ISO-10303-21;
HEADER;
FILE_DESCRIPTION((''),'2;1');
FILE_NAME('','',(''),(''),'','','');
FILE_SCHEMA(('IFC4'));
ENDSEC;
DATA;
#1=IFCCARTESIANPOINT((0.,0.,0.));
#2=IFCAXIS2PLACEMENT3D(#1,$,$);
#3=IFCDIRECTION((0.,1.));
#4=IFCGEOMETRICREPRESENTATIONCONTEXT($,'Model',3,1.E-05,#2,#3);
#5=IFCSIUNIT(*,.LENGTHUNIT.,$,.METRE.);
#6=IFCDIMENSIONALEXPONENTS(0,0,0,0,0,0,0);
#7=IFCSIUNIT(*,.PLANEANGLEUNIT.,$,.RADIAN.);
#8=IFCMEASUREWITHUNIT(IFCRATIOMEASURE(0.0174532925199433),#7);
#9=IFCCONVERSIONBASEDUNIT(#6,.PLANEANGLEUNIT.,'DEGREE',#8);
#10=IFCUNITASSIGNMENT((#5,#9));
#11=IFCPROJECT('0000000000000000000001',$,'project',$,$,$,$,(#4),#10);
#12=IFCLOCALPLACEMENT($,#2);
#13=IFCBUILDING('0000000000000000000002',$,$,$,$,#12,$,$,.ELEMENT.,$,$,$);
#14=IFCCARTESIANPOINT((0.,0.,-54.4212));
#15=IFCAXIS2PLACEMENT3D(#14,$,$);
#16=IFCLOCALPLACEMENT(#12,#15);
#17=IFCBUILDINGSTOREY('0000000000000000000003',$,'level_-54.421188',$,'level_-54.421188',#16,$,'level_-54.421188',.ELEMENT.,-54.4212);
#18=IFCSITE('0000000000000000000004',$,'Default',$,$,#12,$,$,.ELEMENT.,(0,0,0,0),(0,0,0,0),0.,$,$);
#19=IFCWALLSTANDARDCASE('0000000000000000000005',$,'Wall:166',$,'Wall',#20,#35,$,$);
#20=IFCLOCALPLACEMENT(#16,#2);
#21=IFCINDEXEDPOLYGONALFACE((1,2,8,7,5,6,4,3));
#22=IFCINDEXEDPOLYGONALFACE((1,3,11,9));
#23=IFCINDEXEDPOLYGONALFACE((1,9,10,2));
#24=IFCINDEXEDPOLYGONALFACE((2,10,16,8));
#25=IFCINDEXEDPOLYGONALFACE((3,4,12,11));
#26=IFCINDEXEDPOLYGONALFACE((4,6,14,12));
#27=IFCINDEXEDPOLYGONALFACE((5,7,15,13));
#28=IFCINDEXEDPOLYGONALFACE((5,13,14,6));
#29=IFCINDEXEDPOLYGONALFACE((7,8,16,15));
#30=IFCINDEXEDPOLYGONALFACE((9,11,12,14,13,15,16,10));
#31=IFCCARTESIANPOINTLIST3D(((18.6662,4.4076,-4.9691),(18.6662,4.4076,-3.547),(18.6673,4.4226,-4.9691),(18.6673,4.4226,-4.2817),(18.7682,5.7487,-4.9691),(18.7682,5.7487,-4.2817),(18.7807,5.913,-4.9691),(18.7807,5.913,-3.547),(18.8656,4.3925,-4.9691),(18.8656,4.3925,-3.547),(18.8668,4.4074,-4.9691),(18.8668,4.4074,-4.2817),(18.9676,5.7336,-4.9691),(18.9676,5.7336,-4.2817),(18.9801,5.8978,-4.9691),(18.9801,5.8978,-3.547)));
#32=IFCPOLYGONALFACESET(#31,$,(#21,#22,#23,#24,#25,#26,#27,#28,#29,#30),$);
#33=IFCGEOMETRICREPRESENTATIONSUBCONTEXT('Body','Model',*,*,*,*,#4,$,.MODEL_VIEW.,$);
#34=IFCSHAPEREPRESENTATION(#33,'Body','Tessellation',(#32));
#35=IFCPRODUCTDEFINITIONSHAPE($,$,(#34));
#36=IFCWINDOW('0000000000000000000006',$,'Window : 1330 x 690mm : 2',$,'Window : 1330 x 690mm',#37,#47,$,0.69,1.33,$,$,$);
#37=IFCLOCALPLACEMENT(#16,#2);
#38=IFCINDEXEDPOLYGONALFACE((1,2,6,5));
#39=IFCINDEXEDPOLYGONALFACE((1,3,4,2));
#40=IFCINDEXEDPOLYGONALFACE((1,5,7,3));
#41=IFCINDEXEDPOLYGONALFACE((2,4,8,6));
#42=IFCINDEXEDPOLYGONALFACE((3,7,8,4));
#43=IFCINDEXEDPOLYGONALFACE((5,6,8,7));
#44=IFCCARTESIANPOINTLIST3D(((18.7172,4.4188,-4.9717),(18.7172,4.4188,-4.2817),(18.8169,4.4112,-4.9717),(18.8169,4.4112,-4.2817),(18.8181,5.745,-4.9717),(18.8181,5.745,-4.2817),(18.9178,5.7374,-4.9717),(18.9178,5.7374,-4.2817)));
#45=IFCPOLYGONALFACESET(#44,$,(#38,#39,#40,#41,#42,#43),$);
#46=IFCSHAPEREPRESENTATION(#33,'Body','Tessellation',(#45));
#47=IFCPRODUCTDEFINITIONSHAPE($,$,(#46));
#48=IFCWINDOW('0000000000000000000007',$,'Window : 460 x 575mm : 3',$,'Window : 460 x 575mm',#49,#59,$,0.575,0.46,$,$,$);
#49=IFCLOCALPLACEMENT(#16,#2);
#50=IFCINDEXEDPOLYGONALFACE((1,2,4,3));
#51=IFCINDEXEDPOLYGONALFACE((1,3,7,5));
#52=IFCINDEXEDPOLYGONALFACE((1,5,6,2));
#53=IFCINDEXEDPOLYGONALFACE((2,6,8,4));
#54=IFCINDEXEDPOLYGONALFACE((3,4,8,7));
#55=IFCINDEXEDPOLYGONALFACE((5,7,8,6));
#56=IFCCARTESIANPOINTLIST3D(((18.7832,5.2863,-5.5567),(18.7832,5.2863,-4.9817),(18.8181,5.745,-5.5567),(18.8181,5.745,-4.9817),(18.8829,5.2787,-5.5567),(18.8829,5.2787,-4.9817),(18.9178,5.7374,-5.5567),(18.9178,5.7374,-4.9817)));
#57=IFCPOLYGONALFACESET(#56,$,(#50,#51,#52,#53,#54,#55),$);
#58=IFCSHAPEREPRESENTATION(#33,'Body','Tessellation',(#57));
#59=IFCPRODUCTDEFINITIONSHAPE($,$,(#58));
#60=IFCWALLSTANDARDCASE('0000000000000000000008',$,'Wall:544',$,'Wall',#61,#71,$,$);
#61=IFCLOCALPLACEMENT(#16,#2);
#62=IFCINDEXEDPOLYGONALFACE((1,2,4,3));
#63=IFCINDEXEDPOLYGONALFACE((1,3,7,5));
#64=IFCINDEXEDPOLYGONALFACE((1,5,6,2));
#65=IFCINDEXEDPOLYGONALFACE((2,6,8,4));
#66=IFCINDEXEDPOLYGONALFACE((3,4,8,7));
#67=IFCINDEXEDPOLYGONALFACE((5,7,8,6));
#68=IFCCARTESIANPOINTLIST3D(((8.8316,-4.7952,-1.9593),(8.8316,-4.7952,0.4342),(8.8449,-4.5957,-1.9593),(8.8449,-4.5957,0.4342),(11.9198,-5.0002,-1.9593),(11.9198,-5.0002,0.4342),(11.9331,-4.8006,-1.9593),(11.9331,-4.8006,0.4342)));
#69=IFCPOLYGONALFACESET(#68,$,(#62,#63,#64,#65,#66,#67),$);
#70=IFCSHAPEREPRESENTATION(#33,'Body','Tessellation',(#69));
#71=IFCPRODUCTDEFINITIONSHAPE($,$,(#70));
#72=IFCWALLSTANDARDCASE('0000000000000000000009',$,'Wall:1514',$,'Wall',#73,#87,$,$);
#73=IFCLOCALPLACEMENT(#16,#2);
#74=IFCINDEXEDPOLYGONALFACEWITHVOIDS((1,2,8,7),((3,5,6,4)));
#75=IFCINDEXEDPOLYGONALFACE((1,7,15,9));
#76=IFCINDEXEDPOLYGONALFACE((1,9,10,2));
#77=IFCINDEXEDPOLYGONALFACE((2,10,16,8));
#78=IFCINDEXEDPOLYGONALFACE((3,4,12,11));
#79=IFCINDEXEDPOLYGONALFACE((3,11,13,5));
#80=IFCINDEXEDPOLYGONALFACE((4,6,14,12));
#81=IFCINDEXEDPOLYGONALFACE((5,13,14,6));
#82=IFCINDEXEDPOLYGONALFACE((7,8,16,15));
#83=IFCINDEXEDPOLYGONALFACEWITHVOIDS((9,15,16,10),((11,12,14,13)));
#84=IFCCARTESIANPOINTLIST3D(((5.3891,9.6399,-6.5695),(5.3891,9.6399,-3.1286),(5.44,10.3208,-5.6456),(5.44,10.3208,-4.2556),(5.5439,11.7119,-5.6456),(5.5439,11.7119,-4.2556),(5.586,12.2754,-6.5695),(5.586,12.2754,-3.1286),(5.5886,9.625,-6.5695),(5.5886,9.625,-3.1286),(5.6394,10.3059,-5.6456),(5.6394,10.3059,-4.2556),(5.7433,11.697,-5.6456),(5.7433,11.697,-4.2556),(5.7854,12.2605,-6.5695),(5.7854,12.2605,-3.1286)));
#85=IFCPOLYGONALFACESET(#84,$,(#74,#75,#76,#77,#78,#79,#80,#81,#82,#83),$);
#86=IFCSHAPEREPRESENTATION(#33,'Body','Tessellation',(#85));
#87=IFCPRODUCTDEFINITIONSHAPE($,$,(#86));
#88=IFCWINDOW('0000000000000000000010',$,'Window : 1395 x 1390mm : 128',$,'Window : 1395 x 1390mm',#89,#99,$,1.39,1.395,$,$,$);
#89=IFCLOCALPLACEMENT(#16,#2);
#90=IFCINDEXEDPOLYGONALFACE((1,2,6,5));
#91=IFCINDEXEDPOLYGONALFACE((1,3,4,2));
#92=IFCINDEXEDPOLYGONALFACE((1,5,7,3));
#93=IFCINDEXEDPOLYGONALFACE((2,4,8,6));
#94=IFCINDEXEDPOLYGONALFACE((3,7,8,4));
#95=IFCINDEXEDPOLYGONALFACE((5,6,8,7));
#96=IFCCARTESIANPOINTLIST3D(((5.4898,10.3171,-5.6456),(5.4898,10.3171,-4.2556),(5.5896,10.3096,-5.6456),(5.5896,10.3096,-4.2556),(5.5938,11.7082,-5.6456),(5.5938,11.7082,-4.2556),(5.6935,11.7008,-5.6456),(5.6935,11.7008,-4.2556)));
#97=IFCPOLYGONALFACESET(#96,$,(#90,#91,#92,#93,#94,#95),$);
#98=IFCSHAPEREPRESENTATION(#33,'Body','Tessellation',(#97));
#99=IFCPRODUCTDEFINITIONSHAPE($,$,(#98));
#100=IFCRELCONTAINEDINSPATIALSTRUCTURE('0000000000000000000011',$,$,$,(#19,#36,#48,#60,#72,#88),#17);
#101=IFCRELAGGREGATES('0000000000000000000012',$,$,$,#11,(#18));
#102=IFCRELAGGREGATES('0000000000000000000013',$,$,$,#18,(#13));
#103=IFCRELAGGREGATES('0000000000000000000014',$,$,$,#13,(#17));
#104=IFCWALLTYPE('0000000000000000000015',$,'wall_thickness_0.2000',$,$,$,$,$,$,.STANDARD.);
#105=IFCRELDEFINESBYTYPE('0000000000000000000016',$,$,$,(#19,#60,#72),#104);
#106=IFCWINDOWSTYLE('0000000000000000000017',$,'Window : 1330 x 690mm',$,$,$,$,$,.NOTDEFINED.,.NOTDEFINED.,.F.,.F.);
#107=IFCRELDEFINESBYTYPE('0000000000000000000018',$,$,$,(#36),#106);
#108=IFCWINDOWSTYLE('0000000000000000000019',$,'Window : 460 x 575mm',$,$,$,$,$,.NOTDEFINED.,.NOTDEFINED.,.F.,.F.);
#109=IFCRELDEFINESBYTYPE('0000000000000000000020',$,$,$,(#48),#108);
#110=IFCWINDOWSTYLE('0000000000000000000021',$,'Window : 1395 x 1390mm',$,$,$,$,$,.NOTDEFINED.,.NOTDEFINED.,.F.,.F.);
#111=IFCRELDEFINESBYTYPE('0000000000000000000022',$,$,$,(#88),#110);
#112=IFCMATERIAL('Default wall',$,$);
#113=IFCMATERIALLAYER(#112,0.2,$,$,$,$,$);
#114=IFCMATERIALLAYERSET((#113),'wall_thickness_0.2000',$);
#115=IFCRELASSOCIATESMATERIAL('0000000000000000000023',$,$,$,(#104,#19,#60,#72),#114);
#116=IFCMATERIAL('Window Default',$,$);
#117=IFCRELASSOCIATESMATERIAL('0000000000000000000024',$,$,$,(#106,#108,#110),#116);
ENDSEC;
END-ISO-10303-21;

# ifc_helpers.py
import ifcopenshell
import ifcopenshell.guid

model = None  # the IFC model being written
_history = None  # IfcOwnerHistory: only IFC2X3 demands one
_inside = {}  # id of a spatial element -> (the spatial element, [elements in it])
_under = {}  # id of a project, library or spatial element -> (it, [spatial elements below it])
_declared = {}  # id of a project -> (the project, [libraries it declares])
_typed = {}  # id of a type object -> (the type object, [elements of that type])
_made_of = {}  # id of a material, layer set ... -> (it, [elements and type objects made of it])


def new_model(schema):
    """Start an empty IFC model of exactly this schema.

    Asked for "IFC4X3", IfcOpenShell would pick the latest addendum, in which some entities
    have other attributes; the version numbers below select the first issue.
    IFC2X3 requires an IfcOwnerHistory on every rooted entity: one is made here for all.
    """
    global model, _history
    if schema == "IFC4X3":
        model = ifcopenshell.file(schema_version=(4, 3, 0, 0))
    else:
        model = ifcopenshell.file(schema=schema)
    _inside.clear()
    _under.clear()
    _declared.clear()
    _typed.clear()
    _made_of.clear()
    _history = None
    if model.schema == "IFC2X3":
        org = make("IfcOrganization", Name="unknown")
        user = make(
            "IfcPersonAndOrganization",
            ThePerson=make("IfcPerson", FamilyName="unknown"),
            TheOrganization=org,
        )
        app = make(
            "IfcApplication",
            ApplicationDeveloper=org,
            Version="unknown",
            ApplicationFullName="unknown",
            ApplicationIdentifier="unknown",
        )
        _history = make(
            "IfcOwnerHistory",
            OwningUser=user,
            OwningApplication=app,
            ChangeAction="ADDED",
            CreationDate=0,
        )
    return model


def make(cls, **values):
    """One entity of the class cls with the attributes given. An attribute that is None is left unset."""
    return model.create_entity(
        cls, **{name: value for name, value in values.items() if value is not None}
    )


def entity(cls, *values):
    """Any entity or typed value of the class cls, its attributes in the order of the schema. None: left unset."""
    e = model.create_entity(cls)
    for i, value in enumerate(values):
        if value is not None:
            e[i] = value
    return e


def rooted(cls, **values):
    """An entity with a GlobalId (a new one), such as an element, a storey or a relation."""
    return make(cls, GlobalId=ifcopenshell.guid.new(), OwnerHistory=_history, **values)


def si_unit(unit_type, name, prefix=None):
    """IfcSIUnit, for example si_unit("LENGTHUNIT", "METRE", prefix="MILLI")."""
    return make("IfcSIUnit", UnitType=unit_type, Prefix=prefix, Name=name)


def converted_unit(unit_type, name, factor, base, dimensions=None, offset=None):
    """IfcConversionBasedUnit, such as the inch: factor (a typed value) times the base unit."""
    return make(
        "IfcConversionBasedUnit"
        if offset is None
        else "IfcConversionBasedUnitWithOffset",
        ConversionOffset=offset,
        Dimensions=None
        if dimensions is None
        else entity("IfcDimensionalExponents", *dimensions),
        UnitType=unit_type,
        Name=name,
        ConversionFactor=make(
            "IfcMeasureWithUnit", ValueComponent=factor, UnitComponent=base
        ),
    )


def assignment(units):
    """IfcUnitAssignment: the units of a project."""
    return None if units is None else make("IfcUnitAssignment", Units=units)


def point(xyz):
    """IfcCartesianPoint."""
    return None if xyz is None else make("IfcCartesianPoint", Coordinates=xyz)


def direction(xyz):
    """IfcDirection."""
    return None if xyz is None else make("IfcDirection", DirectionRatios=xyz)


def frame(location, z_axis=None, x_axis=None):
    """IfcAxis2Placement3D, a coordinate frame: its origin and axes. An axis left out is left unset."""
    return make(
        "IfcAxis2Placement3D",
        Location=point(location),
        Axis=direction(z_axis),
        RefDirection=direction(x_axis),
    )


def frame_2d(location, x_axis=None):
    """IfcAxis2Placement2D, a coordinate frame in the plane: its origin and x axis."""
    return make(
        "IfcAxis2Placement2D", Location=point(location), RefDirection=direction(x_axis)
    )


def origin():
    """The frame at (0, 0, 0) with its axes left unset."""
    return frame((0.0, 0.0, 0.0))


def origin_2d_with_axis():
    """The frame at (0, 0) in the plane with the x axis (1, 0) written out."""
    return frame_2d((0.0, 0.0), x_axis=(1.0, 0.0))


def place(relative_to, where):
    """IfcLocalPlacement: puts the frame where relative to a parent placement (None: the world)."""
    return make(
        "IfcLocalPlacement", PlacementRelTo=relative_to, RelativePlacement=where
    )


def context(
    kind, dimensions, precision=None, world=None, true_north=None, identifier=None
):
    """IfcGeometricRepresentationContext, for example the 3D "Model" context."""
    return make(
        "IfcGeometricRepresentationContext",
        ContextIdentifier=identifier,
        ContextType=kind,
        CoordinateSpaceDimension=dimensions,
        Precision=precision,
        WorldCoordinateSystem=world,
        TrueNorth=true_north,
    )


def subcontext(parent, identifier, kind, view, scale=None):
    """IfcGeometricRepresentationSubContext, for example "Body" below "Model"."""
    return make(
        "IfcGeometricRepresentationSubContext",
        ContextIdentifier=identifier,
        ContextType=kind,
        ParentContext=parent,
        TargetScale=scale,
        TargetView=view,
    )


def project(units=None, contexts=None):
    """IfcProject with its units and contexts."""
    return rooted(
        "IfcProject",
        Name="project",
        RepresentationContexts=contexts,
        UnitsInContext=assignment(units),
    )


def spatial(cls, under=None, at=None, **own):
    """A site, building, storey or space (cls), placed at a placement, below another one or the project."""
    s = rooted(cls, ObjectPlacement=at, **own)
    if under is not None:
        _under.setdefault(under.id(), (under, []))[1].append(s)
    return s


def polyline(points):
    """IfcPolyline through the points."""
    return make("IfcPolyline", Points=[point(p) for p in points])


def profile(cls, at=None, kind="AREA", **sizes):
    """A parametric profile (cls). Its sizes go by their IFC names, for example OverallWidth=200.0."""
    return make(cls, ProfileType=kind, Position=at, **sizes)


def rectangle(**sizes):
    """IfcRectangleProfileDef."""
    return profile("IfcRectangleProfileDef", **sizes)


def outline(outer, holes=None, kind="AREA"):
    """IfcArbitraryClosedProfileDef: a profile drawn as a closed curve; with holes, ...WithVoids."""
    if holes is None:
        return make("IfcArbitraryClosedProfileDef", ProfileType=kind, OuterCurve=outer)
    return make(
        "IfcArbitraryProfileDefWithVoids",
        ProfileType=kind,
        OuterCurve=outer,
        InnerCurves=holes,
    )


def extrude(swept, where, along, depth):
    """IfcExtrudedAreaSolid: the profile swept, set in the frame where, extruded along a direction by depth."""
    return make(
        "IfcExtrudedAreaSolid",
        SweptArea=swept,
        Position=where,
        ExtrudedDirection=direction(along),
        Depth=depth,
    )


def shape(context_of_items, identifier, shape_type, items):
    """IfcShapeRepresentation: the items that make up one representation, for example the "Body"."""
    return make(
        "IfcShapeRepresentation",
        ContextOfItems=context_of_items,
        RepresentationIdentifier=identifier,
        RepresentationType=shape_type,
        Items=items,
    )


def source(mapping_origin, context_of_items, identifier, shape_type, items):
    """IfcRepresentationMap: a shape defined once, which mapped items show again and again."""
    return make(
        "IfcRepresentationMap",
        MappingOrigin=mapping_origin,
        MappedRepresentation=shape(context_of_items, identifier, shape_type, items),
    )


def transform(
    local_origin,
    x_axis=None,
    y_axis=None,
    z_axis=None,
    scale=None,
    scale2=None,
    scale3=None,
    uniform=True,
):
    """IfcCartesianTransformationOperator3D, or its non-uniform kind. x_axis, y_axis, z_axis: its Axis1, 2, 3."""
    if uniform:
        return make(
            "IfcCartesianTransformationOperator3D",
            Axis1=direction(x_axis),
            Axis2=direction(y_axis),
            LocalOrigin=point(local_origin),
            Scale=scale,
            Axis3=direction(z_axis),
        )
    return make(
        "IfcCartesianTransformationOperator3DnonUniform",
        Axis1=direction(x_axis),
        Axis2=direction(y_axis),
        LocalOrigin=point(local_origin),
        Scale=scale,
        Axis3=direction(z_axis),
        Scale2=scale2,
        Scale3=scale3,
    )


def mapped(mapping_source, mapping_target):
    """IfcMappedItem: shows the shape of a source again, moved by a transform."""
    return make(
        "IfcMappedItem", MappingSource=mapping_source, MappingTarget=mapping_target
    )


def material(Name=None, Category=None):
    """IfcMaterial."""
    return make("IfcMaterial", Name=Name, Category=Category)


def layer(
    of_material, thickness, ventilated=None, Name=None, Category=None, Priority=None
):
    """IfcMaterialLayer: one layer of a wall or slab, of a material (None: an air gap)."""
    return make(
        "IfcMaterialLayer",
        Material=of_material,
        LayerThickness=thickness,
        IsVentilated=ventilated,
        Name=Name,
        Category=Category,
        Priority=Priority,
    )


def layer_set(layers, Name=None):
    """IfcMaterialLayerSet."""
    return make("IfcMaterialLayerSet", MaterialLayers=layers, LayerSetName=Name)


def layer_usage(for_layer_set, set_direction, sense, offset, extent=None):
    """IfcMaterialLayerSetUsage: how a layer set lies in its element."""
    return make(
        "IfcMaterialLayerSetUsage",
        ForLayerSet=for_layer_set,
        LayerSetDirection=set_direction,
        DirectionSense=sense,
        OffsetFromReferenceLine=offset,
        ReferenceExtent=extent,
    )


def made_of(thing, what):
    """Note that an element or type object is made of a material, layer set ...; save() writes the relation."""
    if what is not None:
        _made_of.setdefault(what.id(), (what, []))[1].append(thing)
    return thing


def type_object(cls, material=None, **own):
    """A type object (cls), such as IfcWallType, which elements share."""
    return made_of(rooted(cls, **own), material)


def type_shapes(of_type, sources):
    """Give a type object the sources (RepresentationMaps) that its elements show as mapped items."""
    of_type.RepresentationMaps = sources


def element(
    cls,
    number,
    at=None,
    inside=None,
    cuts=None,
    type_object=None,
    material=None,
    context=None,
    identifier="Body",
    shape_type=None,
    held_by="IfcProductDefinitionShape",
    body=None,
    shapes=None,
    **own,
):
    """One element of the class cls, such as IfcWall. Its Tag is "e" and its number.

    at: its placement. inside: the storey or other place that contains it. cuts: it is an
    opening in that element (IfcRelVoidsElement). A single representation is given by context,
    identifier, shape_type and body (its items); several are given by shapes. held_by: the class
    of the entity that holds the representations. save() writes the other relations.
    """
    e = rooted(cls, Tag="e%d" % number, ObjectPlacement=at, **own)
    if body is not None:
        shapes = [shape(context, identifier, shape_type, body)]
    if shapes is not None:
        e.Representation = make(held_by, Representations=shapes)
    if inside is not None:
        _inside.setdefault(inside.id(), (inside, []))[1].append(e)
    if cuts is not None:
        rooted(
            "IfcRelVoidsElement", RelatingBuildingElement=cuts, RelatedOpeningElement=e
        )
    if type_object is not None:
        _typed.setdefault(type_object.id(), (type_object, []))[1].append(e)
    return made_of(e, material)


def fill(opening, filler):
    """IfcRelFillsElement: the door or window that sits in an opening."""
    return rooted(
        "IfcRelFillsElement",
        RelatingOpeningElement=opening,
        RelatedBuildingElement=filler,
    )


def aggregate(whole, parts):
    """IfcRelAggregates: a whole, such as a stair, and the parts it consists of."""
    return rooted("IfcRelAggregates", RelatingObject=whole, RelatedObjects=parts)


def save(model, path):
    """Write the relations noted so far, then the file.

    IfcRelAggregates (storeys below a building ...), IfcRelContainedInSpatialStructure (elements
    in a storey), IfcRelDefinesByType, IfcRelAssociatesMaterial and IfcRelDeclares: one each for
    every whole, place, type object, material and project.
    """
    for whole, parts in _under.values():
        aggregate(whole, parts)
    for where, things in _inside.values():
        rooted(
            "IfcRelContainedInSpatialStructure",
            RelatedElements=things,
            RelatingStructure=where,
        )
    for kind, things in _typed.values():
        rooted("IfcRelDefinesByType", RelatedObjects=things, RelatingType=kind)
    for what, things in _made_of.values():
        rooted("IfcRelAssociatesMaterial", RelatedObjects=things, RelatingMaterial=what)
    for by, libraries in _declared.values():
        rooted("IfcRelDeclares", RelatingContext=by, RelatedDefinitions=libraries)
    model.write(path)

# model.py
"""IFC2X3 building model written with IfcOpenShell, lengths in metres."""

from ifc_helpers import new_model, entity, si_unit, converted_unit, direction, frame, frame_2d, origin, origin_2d_with_axis, place, context, subcontext, project, spatial, polyline, rectangle, outline, extrude, source, transform, mapped, material, layer, layer_set, layer_usage, type_object, type_shapes, element, fill, save


model = new_model("IFC2X3")

# Units and contexts
model_context = context("Model", 3, precision=1e-05, world=origin(), true_north=direction((0.0, 1.0)))
body_context = subcontext(model_context, "Body", "Model", "MODEL_VIEW")
ifc_project = project(units=[si_unit("LENGTHUNIT", "METRE"), converted_unit("PLANEANGLEUNIT", "DEGREE", entity("IfcRatioMeasure", 0.0174532925199433), si_unit("PLANEANGLEUNIT", "RADIAN"), dimensions=[0, 0, 0, 0, 0, 0, 0])], contexts=[model_context])

# Site, building, storey
placement_1 = place(None, origin())
site = spatial("IfcSite", under=ifc_project, at=placement_1, Name="Default", CompositionType="ELEMENT", RefLatitude=(0, 0, 0, 0), RefLongitude=(0, 0, 0, 0), RefElevation=0.0)
building = spatial("IfcBuilding", under=site, at=placement_1, CompositionType="ELEMENT")
storey_placement = place(placement_1, frame((0.0, 0.0, -54.4212)))
storey = spatial("IfcBuildingStorey", under=building, at=storey_placement, Name="level_-54.421188", ObjectType="level_-54.421188", LongName="level_-54.421188", CompositionType="ELEMENT", Elevation=-54.4212)

# Wall, openings, windows
ifc_material_1 = material(Name="Default wall")
ifc_layer = layer(ifc_material_1, 0.2)
ifc_layer_set = layer_set([ifc_layer], Name="wall_thickness_0.2000")
ifc_layer_usage = layer_usage(ifc_layer_set, "AXIS2", "POSITIVE", -0.1)
wall_type = type_object("IfcWallType", Name="wall_thickness_0.2000", PredefinedType="STANDARD", material=ifc_layer_set)
placement_2 = place(placement_1, frame((0.0, 0.0, -59.3903)))
wall_1_placement = place(placement_2, frame((18.8804, 5.9054, 0.0), z_axis=(0.0, 0.0, 1.0), x_axis=(-0.075843, -0.99712, 0.0)))
wall_1 = element("IfcWallStandardCase", 1, at=wall_1_placement, inside=storey, type_object=wall_type, material=ifc_layer_usage, Name="Wall:166", ObjectType="Wall", context=body_context, shape_type="SweptSolid", body=[
    extrude(outline(polyline([(1.5097, -0.1), (1.5097, 0.1), (0.0, 0.1), (0.0, -0.1), (1.5097, -0.1)])), origin(), (0.0, 0.0, 1.0), 1.4221),
])
opening_1_placement = place(wall_1_placement, frame((0.1647, -0.1, -0.0026)))
opening_1 = element("IfcOpeningElement", 2, at=opening_1_placement, cuts=wall_1, ObjectType="Opening", context=body_context, shape_type="SweptSolid", body=[
    extrude(rectangle(XDim=1.33, YDim=0.69, at=frame_2d((0.345, 0.665), x_axis=(0.0, 1.0))), frame((0.0, 0.0, 0.0), z_axis=(0.0, 1.0, 0.0), x_axis=(0.0, 0.0, 1.0)), (0.0, 0.0, 1.0), 0.2),
])
opening_2_placement = place(wall_1_placement, frame((0.1647, -0.1, -0.5876)))
opening_2 = element("IfcOpeningElement", 3, at=opening_2_placement, cuts=wall_1, ObjectType="Opening", context=body_context, shape_type="SweptSolid", body=[
    extrude(rectangle(XDim=0.46, YDim=0.575, at=frame_2d((0.2875, 0.23), x_axis=(0.0, 1.0))), frame((0.0, 0.0, 0.0), z_axis=(0.0, 1.0, 0.0), x_axis=(0.0, 0.0, 1.0)), (0.0, 0.0, 1.0), 0.2),
])
ifc_material_2 = material(Name="Window Default")
window_style_1 = type_object("IfcWindowStyle", Name="Window : 1330 x 690mm", ConstructionType="NOTDEFINED", OperationType="NOTDEFINED", ParameterTakesPrecedence=False, Sizeable=False, material=ifc_material_2)
shared_shape_1 = source(origin(), body_context, "Body", "SweptSolid", [
    extrude(rectangle(XDim=0.1, YDim=1.33, at=origin_2d_with_axis()), frame((0.665, 0.1, 0.0), z_axis=(0.0, 0.0, 1.0), x_axis=(0.0, 1.0, 0.0)), (0.0, 0.0, 1.0), 0.69),
])
type_shapes(window_style_1, [shared_shape_1])
window_1_placement = place(opening_1_placement, origin())
window_1 = element("IfcWindow", 4, at=window_1_placement, inside=storey, type_object=window_style_1, Name="Window : 1330 x 690mm : 2", ObjectType="Window : 1330 x 690mm", OverallHeight=0.69, OverallWidth=1.33, context=body_context, shape_type="MappedRepresentation", body=[
    mapped(shared_shape_1, transform((0.0, 0.0, 0.0), scale=1.0)),
])
fill(opening_1, window_1)
window_style_2 = type_object("IfcWindowStyle", Name="Window : 460 x 575mm", ConstructionType="NOTDEFINED", OperationType="NOTDEFINED", ParameterTakesPrecedence=False, Sizeable=False, material=ifc_material_2)
shared_shape_2 = source(origin(), body_context, "Body", "SweptSolid", [
    extrude(rectangle(XDim=0.1, YDim=0.46, at=origin_2d_with_axis()), frame((0.23, 0.1, 0.0), z_axis=(0.0, 0.0, 1.0), x_axis=(0.0, 1.0, 0.0)), (0.0, 0.0, 1.0), 0.575),
])
type_shapes(window_style_2, [shared_shape_2])
window_2_placement = place(opening_2_placement, origin())
window_2 = element("IfcWindow", 5, at=window_2_placement, inside=storey, type_object=window_style_2, Name="Window : 460 x 575mm : 3", ObjectType="Window : 460 x 575mm", OverallHeight=0.575, OverallWidth=0.46, context=body_context, shape_type="MappedRepresentation", body=[
    mapped(shared_shape_2, transform((0.0, 0.0, 0.0), scale=1.0)),
])
fill(opening_2, window_2)

# Wall
placement_3 = place(placement_1, frame((0.0, 0.0, -56.3805)))
wall_2_placement = place(placement_3, frame((8.8382, -4.6955, 0.0), z_axis=(0.0, 0.0, 1.0), x_axis=(0.997805, -0.066215, 0.0)))
element("IfcWallStandardCase", 6, at=wall_2_placement, inside=storey, type_object=wall_type, material=ifc_layer_usage, Name="Wall:544", ObjectType="Wall", context=body_context, shape_type="SweptSolid", body=[
    extrude(outline(polyline([(3.095, -0.1), (3.095, 0.1), (0.0, 0.1), (0.0, -0.1), (3.095, -0.1)])), origin(), (0.0, 0.0, 1.0), 2.3935),
])

# Wall, opening, window
placement_4 = place(placement_1, frame((0.0, 0.0, -60.9907)))
wall_3_placement = place(placement_4, frame((5.6857, 12.2679, 0.0), z_axis=(0.0, 0.0, 1.0), x_axis=(-0.074493, -0.997222, 0.0)))
wall_3 = element("IfcWallStandardCase", 7, at=wall_3_placement, inside=storey, type_object=wall_type, material=ifc_layer_usage, Name="Wall:1514", ObjectType="Wall", context=body_context, shape_type="SweptSolid", body=[
    extrude(outline(polyline([(2.6428, -0.1), (2.6428, 0.1), (0.0, 0.1), (0.0, -0.1), (2.6428, -0.1)])), origin(), (0.0, 0.0, 1.0), 3.4409),
])
opening_3_placement = place(wall_3_placement, frame((0.565, -0.1, 0.9239)))
opening_3 = element("IfcOpeningElement", 8, at=opening_3_placement, cuts=wall_3, ObjectType="Opening", context=body_context, shape_type="SweptSolid", body=[
    extrude(rectangle(XDim=1.395, YDim=1.39, at=frame_2d((0.695, 0.6975), x_axis=(0.0, 1.0))), frame((0.0, 0.0, 0.0), z_axis=(0.0, 1.0, 0.0), x_axis=(0.0, 0.0, 1.0)), (0.0, 0.0, 1.0), 0.2),
])
window_style_3 = type_object("IfcWindowStyle", Name="Window : 1395 x 1390mm", ConstructionType="NOTDEFINED", OperationType="NOTDEFINED", ParameterTakesPrecedence=False, Sizeable=False, material=ifc_material_2)
shared_shape_3 = source(origin(), body_context, "Body", "SweptSolid", [
    extrude(rectangle(XDim=0.1, YDim=1.395, at=origin_2d_with_axis()), frame((0.6975, 0.1, 0.0), z_axis=(0.0, 0.0, 1.0), x_axis=(0.0, 1.0, 0.0)), (0.0, 0.0, 1.0), 1.39),
])
type_shapes(window_style_3, [shared_shape_3])
window_3_placement = place(opening_3_placement, origin())
window_3 = element("IfcWindow", 9, at=window_3_placement, inside=storey, type_object=window_style_3, Name="Window : 1395 x 1390mm : 128", ObjectType="Window : 1395 x 1390mm", OverallHeight=1.39, OverallWidth=1.395, context=body_context, shape_type="MappedRepresentation", body=[
    mapped(shared_shape_3, transform((0.0, 0.0, 0.0), scale=1.0)),
])
fill(opening_3, window_3)

save(model, "model.ifc")
